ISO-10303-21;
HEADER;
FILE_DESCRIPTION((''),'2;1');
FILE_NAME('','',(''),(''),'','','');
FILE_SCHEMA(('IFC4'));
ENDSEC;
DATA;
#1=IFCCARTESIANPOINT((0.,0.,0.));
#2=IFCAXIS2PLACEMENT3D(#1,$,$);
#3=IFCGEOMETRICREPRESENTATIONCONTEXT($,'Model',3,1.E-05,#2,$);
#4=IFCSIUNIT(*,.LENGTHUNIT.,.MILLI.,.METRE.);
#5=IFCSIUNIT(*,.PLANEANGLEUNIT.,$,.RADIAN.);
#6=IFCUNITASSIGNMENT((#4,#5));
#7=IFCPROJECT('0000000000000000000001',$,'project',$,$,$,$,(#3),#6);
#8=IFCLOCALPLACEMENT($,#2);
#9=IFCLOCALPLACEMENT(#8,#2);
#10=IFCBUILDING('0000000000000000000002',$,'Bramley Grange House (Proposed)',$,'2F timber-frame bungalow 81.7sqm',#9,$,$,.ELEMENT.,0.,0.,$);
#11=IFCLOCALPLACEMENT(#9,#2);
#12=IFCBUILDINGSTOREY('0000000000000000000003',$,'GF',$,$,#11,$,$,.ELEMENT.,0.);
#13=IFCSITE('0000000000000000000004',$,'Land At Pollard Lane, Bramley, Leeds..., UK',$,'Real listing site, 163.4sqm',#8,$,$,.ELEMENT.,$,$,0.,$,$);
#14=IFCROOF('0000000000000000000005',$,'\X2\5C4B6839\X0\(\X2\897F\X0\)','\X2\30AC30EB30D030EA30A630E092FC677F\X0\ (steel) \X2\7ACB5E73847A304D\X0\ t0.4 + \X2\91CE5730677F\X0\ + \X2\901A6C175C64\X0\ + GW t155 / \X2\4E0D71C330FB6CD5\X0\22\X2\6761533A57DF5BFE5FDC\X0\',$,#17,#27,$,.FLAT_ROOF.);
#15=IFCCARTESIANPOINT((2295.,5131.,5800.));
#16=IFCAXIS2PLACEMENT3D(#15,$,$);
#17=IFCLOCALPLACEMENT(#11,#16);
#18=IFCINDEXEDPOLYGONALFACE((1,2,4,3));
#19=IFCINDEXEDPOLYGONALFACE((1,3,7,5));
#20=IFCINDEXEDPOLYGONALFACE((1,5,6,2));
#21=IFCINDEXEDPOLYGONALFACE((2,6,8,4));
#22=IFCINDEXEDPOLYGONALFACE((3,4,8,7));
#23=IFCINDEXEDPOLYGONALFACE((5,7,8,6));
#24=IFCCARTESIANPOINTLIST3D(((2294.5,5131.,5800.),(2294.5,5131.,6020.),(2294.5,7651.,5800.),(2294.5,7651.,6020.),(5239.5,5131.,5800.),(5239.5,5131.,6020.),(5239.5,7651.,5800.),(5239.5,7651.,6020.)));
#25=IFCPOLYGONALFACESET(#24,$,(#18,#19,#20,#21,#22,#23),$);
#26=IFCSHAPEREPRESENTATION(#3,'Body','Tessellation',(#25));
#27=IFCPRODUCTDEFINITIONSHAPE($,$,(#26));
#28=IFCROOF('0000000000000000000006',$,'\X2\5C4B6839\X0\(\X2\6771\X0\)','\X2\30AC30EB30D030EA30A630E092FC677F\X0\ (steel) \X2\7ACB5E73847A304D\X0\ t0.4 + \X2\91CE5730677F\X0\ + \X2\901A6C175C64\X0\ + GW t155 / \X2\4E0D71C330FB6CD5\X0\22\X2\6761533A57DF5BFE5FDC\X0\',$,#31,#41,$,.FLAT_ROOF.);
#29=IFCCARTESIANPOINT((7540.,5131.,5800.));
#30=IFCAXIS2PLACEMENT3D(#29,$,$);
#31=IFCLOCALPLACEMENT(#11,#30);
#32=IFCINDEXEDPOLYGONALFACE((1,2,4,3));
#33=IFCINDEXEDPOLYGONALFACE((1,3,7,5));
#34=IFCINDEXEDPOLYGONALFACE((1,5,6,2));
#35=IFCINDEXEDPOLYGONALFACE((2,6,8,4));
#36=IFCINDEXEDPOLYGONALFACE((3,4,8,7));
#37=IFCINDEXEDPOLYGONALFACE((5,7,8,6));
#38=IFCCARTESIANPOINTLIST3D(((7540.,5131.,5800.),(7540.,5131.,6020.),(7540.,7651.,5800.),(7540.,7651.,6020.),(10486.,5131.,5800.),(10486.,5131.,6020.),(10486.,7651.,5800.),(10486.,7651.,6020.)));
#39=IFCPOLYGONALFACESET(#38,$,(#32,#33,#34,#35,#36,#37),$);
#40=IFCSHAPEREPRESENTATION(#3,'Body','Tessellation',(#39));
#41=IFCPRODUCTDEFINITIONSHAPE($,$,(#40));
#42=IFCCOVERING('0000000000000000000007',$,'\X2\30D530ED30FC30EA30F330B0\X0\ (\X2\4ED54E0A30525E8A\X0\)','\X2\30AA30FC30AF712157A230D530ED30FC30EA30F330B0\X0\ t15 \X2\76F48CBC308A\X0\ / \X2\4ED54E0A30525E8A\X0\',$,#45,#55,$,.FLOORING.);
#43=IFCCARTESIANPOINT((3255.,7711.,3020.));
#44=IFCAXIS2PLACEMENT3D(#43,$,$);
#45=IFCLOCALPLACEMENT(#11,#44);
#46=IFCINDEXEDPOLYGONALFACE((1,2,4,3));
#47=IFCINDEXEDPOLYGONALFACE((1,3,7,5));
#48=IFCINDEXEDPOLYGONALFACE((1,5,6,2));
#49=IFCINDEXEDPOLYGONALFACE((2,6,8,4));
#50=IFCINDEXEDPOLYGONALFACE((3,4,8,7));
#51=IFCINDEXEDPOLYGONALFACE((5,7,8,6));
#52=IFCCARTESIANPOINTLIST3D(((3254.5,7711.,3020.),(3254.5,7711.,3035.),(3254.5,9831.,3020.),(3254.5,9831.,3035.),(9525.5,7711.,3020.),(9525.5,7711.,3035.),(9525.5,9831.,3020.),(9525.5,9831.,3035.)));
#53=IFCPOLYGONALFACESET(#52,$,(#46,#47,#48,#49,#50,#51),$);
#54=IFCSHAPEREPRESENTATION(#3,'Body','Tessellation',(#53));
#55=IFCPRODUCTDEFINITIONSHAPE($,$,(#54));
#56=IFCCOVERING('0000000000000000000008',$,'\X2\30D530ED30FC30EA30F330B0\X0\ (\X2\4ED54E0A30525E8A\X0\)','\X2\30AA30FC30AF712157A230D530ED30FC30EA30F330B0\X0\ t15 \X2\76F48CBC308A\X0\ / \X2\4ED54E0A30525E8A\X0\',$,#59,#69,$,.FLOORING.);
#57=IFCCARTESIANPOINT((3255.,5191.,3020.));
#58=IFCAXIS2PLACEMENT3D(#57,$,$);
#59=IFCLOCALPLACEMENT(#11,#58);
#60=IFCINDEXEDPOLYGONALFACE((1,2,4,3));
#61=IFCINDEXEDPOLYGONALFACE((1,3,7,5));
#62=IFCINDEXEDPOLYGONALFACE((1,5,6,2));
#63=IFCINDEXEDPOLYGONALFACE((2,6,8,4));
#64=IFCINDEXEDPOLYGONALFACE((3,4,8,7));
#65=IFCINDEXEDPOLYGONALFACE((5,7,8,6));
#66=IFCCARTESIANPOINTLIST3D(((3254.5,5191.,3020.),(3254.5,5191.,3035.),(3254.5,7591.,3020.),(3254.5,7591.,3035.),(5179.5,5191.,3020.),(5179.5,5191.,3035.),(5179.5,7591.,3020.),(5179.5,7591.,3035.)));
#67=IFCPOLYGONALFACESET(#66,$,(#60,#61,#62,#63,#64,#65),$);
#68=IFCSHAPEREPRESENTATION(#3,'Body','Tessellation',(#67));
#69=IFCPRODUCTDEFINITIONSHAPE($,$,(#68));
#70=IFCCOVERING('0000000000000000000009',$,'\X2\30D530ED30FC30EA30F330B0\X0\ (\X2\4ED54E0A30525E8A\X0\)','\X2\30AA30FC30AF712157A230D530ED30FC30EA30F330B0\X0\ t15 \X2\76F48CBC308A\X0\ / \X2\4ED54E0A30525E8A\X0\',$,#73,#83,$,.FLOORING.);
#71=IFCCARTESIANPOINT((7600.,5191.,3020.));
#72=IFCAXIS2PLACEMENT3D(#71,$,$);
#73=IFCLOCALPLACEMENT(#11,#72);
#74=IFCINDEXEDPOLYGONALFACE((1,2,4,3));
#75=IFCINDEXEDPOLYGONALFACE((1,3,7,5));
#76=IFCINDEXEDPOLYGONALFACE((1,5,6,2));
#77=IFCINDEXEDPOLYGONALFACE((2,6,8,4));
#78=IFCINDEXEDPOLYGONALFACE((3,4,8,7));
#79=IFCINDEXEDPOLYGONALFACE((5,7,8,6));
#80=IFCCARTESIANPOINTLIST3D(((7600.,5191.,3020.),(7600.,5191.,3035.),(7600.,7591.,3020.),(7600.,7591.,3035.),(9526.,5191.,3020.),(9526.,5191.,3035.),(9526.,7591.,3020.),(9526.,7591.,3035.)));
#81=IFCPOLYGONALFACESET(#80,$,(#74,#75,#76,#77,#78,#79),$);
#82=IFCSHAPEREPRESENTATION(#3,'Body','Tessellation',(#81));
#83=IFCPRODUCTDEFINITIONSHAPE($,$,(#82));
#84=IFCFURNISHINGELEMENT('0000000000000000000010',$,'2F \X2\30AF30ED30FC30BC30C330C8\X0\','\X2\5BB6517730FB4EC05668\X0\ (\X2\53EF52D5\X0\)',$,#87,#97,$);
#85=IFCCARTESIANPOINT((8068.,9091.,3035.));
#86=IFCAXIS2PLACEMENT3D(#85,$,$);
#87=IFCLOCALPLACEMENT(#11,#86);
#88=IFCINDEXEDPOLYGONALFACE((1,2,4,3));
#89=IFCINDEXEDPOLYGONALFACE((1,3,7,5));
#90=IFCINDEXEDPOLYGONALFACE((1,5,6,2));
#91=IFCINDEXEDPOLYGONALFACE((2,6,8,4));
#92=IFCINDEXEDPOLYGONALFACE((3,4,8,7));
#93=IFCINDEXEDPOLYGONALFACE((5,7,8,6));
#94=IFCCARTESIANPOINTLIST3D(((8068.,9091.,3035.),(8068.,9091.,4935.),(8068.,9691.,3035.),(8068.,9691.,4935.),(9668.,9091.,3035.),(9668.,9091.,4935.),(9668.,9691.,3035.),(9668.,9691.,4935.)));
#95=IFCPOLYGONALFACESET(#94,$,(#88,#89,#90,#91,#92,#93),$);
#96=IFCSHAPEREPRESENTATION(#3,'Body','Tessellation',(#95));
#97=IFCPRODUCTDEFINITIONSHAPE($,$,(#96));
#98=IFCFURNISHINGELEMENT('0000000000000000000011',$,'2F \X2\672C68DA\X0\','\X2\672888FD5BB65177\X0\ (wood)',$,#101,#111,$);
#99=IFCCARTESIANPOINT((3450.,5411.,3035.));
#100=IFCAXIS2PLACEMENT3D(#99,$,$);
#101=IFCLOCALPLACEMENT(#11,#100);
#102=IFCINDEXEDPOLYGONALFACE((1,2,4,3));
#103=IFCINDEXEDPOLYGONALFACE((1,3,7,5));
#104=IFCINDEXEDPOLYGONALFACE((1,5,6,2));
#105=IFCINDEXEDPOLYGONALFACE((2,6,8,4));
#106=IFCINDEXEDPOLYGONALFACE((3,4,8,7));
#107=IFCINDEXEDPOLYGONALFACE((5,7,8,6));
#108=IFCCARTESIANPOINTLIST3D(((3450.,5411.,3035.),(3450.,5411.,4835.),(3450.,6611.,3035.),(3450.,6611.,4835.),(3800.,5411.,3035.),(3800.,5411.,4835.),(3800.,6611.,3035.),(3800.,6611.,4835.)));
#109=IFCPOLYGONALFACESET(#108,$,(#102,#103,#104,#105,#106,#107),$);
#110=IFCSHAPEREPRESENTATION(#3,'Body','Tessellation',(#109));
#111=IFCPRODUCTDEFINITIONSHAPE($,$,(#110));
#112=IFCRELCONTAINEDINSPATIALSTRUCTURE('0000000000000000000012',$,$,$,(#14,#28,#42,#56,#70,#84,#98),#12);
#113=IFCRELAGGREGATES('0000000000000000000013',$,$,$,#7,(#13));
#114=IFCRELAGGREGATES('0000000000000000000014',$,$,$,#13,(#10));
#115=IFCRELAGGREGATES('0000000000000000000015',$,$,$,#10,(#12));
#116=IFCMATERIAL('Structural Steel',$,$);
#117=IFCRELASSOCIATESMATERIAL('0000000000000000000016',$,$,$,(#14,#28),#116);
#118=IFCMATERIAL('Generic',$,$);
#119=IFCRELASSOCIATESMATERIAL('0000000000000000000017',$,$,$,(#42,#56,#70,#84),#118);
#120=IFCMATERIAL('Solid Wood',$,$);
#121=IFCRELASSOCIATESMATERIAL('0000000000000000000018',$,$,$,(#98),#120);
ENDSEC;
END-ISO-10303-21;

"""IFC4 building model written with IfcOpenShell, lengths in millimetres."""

from ifc_helpers import new_model, si_unit, frame, frame_2d, origin, place, context, project, spatial, rectangle, extrude, material, element, save


model = new_model("IFC4")

# Units and contexts
model_context = context("Model", 3, precision=1e-05, world=origin())
ifc_project = project(units=[si_unit("LENGTHUNIT", "METRE", prefix="MILLI"), si_unit("PLANEANGLEUNIT", "RADIAN")], contexts=[model_context])

# Site, building, storey
site_placement = place(None, origin())
site = spatial("IfcSite", under=ifc_project, at=site_placement, Name="Land At Pollard Lane, Bramley, Leeds..., UK", ObjectType="Real listing site, 163.4sqm", CompositionType="ELEMENT", RefElevation=0.0)
building_placement = place(site_placement, origin())
building = spatial("IfcBuilding", under=site, at=building_placement, Name="Bramley Grange House (Proposed)", ObjectType="2F timber-frame bungalow 81.7sqm", CompositionType="ELEMENT", ElevationOfRefHeight=0.0, ElevationOfTerrain=0.0)
storey_placement = place(building_placement, origin())
storey = spatial("IfcBuildingStorey", under=building, at=storey_placement, Name="GF", CompositionType="ELEMENT", Elevation=0.0)

# Shared definitions
ifc_material_1 = material(Name="Solid Wood")

# Roofs
ifc_material_2 = material(Name="Structural Steel")
roof_1_placement = place(storey_placement, frame((2295.0, 5131.0, 5800.0)))
element("IfcRoof", 1, at=roof_1_placement, inside=storey, material=ifc_material_2, Name="屋根(西)", Description="ガルバリウム鋼板 (steel) 立平葺き t0.4 + 野地板 + 通気層 + GW t155 / 不燃・法22条区域対応", PredefinedType="FLAT_ROOF", context=model_context, shape_type="SweptSolid", body=[
    extrude(rectangle(XDim=2945.0, YDim=2520.0, at=frame_2d((1472.0, 1260.0))), frame((2295.0, 5131.0, 5800.0)), (0.0, 0.0, 1.0), 220.0),
])
roof_2_placement = place(storey_placement, frame((7540.0, 5131.0, 5800.0)))
element("IfcRoof", 2, at=roof_2_placement, inside=storey, material=ifc_material_2, Name="屋根(東)", Description="ガルバリウム鋼板 (steel) 立平葺き t0.4 + 野地板 + 通気層 + GW t155 / 不燃・法22条区域対応", PredefinedType="FLAT_ROOF", context=model_context, shape_type="SweptSolid", body=[
    extrude(rectangle(XDim=2946.0, YDim=2520.0, at=frame_2d((1473.0, 1260.0))), frame((7540.0, 5131.0, 5800.0)), (0.0, 0.0, 1.0), 220.0),
])

# Coverings
ifc_material_3 = material(Name="Generic")
covering_1_placement = place(storey_placement, frame((3255.0, 7711.0, 3020.0)))
element("IfcCovering", 3, at=covering_1_placement, inside=storey, material=ifc_material_3, Name="フローリング (仕上げ床)", Description="オーク無垢フローリング t15 直貼り / 仕上げ床", PredefinedType="FLOORING", context=model_context, shape_type="SweptSolid", body=[
    extrude(rectangle(XDim=6271.0, YDim=2120.0, at=frame_2d((3135.0, 1060.0))), frame((3255.0, 7711.0, 3020.0)), (0.0, 0.0, 1.0), 15.0),
])
covering_2_placement = place(storey_placement, frame((3255.0, 5191.0, 3020.0)))
element("IfcCovering", 4, at=covering_2_placement, inside=storey, material=ifc_material_3, Name="フローリング (仕上げ床)", Description="オーク無垢フローリング t15 直貼り / 仕上げ床", PredefinedType="FLOORING", context=model_context, shape_type="SweptSolid", body=[
    extrude(rectangle(XDim=1925.0, YDim=2400.0, at=frame_2d((962.0, 1200.0))), frame((3255.0, 5191.0, 3020.0)), (0.0, 0.0, 1.0), 15.0),
])
covering_3_placement = place(storey_placement, frame((7600.0, 5191.0, 3020.0)))
element("IfcCovering", 5, at=covering_3_placement, inside=storey, material=ifc_material_3, Name="フローリング (仕上げ床)", Description="オーク無垢フローリング t15 直貼り / 仕上げ床", PredefinedType="FLOORING", context=model_context, shape_type="SweptSolid", body=[
    extrude(rectangle(XDim=1926.0, YDim=2400.0, at=frame_2d((963.0, 1200.0))), frame((7600.0, 5191.0, 3020.0)), (0.0, 0.0, 1.0), 15.0),
])

# Furnishing elements
furnishing_1_placement = place(storey_placement, frame((8068.0, 9091.0, 3035.0)))
element("IfcFurnishingElement", 6, at=furnishing_1_placement, inside=storey, material=ifc_material_3, Name="2F クローゼット", Description="家具・什器 (可動)", context=model_context, shape_type="SweptSolid", body=[
    extrude(rectangle(XDim=1600.0, YDim=600.0, at=frame_2d((800.0, 300.0))), frame((8068.0, 9091.0, 3035.0)), (0.0, 0.0, 1.0), 1900.0),
])
furnishing_2_placement = place(storey_placement, frame((3450.0, 5411.0, 3035.0)))
element("IfcFurnishingElement", 7, at=furnishing_2_placement, inside=storey, material=ifc_material_1, Name="2F 本棚", Description="木製家具 (wood)", context=model_context, shape_type="SweptSolid", body=[
    extrude(rectangle(XDim=350.0, YDim=1200.0, at=frame_2d((175.0, 600.0))), frame((3450.0, 5411.0, 3035.0)), (0.0, 0.0, 1.0), 1800.0),
])

save(model, "model.ifc")
